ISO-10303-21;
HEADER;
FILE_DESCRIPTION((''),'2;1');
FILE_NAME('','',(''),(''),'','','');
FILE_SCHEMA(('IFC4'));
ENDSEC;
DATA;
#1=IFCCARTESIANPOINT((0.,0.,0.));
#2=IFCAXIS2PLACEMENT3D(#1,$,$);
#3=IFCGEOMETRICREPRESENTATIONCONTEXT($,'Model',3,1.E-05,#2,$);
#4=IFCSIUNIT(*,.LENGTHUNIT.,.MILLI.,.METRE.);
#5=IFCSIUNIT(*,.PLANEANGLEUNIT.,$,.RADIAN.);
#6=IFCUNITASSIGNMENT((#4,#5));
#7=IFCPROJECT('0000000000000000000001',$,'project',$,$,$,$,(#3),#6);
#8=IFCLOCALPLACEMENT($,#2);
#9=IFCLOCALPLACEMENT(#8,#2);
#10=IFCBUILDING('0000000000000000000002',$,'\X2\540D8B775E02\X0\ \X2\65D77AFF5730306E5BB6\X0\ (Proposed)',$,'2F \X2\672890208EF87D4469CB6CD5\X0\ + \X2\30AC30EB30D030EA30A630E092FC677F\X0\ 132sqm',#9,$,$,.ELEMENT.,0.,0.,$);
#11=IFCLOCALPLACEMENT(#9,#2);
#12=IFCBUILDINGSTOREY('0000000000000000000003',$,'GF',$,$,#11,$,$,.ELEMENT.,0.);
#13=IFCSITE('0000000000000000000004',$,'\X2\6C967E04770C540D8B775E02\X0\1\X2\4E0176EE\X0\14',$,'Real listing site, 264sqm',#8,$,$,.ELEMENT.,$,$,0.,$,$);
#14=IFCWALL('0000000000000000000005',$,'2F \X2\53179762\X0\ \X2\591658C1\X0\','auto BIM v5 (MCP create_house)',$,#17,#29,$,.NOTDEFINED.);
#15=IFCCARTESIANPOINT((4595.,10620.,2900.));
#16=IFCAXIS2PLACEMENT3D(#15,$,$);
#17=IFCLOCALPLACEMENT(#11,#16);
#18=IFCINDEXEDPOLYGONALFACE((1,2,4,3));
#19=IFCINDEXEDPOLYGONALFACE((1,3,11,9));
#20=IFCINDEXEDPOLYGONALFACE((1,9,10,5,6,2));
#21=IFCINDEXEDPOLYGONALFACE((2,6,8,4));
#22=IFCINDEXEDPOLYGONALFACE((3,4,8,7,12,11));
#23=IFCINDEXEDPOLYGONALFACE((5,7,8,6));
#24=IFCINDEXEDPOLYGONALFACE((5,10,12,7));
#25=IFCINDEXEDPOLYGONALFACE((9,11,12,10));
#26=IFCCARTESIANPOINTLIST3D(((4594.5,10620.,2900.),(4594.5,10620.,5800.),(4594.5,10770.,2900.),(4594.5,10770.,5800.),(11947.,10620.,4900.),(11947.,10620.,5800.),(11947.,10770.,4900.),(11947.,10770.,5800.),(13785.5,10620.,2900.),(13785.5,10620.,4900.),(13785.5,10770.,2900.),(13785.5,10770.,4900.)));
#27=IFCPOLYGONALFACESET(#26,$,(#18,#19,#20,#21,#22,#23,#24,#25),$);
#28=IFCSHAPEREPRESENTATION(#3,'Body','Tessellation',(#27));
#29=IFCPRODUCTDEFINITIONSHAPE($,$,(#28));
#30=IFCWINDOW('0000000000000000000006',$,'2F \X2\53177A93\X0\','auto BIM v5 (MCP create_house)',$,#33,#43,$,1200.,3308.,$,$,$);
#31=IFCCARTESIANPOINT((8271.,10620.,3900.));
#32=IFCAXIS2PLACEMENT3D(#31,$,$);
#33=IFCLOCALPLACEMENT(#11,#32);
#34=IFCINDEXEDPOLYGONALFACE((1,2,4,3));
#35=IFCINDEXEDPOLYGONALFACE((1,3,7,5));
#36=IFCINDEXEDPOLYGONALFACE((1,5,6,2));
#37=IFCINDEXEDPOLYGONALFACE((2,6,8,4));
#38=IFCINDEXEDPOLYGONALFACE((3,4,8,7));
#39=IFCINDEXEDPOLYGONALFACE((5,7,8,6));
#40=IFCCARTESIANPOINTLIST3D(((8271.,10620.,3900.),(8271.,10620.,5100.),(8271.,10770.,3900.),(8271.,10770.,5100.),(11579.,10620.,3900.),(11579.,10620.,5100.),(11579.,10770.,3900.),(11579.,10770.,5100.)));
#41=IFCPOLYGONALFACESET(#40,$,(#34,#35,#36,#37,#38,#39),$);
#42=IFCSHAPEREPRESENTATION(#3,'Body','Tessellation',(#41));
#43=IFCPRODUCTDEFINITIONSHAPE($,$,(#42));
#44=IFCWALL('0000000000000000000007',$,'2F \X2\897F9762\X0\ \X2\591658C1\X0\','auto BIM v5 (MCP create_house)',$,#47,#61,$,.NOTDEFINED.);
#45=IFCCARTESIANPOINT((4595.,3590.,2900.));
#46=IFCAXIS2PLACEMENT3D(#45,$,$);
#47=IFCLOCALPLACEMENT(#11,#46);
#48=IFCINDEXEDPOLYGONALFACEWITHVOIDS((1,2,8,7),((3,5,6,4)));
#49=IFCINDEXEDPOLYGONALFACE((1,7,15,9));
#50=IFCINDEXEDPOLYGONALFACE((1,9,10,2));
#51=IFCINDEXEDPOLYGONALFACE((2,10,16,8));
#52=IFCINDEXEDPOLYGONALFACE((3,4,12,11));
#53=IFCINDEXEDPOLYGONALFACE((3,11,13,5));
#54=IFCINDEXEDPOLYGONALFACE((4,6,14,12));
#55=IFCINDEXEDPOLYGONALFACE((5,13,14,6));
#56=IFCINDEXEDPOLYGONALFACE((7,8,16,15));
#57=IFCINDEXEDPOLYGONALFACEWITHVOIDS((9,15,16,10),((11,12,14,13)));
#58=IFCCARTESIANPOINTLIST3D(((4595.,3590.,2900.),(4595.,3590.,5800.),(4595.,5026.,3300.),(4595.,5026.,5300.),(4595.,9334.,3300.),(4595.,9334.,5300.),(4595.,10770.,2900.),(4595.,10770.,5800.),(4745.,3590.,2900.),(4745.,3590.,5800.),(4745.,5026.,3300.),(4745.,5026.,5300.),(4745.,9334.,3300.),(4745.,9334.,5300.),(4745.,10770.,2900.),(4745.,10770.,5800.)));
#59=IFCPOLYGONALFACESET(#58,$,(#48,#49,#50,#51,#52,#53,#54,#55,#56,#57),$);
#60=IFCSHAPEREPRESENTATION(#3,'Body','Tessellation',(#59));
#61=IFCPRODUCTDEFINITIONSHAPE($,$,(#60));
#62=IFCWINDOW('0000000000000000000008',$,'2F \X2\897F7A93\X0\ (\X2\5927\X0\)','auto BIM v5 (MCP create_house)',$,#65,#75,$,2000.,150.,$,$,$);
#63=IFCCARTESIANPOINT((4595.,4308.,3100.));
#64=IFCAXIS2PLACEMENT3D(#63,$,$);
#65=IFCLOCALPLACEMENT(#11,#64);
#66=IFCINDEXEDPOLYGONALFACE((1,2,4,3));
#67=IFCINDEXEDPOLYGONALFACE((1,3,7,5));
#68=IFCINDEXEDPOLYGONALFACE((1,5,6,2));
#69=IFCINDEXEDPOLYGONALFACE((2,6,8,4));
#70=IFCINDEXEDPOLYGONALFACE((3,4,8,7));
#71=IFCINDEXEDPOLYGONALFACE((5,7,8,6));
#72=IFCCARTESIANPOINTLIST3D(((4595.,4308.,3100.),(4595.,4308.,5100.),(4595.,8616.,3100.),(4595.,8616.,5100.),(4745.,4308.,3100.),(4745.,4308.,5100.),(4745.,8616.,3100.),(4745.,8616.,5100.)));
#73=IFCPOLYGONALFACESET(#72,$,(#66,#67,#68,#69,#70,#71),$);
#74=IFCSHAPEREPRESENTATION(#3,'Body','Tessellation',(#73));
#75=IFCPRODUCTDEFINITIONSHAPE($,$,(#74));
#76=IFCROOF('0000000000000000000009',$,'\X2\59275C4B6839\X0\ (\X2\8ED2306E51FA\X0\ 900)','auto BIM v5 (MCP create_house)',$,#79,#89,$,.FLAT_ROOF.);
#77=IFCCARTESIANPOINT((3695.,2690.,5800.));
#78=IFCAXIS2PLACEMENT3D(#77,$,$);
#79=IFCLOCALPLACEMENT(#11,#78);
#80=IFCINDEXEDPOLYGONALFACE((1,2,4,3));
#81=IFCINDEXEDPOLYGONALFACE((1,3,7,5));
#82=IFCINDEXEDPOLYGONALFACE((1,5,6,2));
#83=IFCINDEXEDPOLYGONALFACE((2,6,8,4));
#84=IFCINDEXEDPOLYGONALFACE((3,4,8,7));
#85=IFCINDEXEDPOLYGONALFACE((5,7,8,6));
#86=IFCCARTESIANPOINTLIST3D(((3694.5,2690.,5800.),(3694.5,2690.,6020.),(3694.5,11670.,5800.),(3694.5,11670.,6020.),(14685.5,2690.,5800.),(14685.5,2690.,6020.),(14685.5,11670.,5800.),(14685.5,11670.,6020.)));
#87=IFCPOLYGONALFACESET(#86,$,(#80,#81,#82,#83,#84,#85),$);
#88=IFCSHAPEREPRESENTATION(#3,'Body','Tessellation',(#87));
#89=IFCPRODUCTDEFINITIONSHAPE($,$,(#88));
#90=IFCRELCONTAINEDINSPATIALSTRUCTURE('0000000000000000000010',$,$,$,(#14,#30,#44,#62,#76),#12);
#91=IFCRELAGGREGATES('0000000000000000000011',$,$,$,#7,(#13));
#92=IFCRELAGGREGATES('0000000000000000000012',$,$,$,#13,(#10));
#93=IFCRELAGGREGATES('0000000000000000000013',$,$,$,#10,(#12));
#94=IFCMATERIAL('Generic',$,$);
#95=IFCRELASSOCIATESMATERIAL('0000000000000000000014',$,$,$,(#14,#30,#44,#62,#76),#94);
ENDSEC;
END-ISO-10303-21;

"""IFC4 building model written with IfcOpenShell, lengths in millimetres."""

from ifc_helpers import new_model, si_unit, frame, frame_2d, origin, place, context, project, spatial, rectangle, extrude, material, element, fill, save


model = new_model("IFC4")

# Units and contexts
model_context = context("Model", 3, precision=1e-05, world=origin())
ifc_project = project(units=[si_unit("LENGTHUNIT", "METRE", prefix="MILLI"), si_unit("PLANEANGLEUNIT", "RADIAN")], contexts=[model_context])

# Site, building, storey
site_placement = place(None, origin())
site = spatial("IfcSite", under=ifc_project, at=site_placement, Name="沖縄県名護市1丁目14", ObjectType="Real listing site, 264sqm", CompositionType="ELEMENT", RefElevation=0.0)
building_placement = place(site_placement, origin())
building = spatial("IfcBuilding", under=site, at=building_placement, Name="名護市 旗竿地の家 (Proposed)", ObjectType="2F 木造軸組構法 + ガルバリウム鋼板 132sqm", CompositionType="ELEMENT", ElevationOfRefHeight=0.0, ElevationOfTerrain=0.0)
storey_placement = place(building_placement, origin())
storey = spatial("IfcBuildingStorey", under=building, at=storey_placement, Name="GF", CompositionType="ELEMENT", Elevation=0.0)

# Shared definitions
ifc_material = material(Name="Generic")

# Walls, openings, windows
wall_1_placement = place(storey_placement, frame((4595.0, 10620.0, 2900.0)))
wall_1 = element("IfcWall", 1, at=wall_1_placement, inside=storey, material=ifc_material, Name="2F 北面 外壁", Description="auto BIM v5 (MCP create_house)", PredefinedType="NOTDEFINED", context=model_context, shape_type="SweptSolid", body=[
    extrude(rectangle(XDim=9191.0, YDim=150.0, at=frame_2d((4595.0, 75.0))), frame((4595.0, 10620.0, 2900.0)), (0.0, 0.0, 1.0), 2900.0),
])
opening_1_placement = place(storey_placement, frame((8271.0, 10620.0, 3900.0)))
opening_1 = element("IfcOpeningElement", 2, at=opening_1_placement, cuts=wall_1, PredefinedType="NOTDEFINED", context=model_context, shape_type="SweptSolid", body=[
    extrude(rectangle(XDim=3308.0, YDim=150.0, at=frame_2d((1654.0, 75.0))), frame((8271.0, 10620.0, 3900.0)), (0.0, 0.0, 1.0), 1200.0),
])
window_1_placement = place(storey_placement, frame((8271.0, 10620.0, 3900.0)))
window_1 = element("IfcWindow", 3, at=window_1_placement, inside=storey, material=ifc_material, Name="2F 北窓", Description="auto BIM v5 (MCP create_house)", OverallHeight=1200.0, OverallWidth=3308.0, context=model_context, shape_type="SweptSolid", body=[
    extrude(rectangle(XDim=3308.0, YDim=150.0, at=frame_2d((1654.0, 75.0))), frame((8271.0, 10620.0, 3900.0)), (0.0, 0.0, 1.0), 1200.0),
])
fill(opening_1, window_1)
wall_2_placement = place(storey_placement, frame((4595.0, 3590.0, 2900.0)))
wall_2 = element("IfcWall", 4, at=wall_2_placement, inside=storey, material=ifc_material, Name="2F 西面 外壁", Description="auto BIM v5 (MCP create_house)", PredefinedType="NOTDEFINED", context=model_context, shape_type="SweptSolid", body=[
    extrude(rectangle(XDim=150.0, YDim=7180.0, at=frame_2d((75.0, 3590.0))), frame((4595.0, 3590.0, 2900.0)), (0.0, 0.0, 1.0), 2900.0),
])
opening_2_placement = place(storey_placement, frame((4595.0, 4308.0, 3100.0)))
opening_2 = element("IfcOpeningElement", 5, at=opening_2_placement, cuts=wall_2, PredefinedType="NOTDEFINED", context=model_context, shape_type="SweptSolid", body=[
    extrude(rectangle(XDim=150.0, YDim=4308.0, at=frame_2d((75.0, 2154.0))), frame((4595.0, 4308.0, 3100.0)), (0.0, 0.0, 1.0), 2000.0),
])
window_2_placement = place(storey_placement, frame((4595.0, 4308.0, 3100.0)))
window_2 = element("IfcWindow", 6, at=window_2_placement, inside=storey, material=ifc_material, Name="2F 西窓 (大)", Description="auto BIM v5 (MCP create_house)", OverallHeight=2000.0, OverallWidth=150.0, context=model_context, shape_type="SweptSolid", body=[
    extrude(rectangle(XDim=150.0, YDim=4308.0, at=frame_2d((75.0, 2154.0))), frame((4595.0, 4308.0, 3100.0)), (0.0, 0.0, 1.0), 2000.0),
])
fill(opening_2, window_2)

# Roof
roof_placement = place(storey_placement, frame((3695.0, 2690.0, 5800.0)))
element("IfcRoof", 7, at=roof_placement, inside=storey, material=ifc_material, Name="大屋根 (軒の出 900)", Description="auto BIM v5 (MCP create_house)", PredefinedType="FLAT_ROOF", context=model_context, shape_type="SweptSolid", body=[
    extrude(rectangle(XDim=10991.0, YDim=8980.0, at=frame_2d((5495.0, 4490.0))), frame((3695.0, 2690.0, 5800.0)), (0.0, 0.0, 1.0), 220.0),
])

save(model, "model.ifc")
